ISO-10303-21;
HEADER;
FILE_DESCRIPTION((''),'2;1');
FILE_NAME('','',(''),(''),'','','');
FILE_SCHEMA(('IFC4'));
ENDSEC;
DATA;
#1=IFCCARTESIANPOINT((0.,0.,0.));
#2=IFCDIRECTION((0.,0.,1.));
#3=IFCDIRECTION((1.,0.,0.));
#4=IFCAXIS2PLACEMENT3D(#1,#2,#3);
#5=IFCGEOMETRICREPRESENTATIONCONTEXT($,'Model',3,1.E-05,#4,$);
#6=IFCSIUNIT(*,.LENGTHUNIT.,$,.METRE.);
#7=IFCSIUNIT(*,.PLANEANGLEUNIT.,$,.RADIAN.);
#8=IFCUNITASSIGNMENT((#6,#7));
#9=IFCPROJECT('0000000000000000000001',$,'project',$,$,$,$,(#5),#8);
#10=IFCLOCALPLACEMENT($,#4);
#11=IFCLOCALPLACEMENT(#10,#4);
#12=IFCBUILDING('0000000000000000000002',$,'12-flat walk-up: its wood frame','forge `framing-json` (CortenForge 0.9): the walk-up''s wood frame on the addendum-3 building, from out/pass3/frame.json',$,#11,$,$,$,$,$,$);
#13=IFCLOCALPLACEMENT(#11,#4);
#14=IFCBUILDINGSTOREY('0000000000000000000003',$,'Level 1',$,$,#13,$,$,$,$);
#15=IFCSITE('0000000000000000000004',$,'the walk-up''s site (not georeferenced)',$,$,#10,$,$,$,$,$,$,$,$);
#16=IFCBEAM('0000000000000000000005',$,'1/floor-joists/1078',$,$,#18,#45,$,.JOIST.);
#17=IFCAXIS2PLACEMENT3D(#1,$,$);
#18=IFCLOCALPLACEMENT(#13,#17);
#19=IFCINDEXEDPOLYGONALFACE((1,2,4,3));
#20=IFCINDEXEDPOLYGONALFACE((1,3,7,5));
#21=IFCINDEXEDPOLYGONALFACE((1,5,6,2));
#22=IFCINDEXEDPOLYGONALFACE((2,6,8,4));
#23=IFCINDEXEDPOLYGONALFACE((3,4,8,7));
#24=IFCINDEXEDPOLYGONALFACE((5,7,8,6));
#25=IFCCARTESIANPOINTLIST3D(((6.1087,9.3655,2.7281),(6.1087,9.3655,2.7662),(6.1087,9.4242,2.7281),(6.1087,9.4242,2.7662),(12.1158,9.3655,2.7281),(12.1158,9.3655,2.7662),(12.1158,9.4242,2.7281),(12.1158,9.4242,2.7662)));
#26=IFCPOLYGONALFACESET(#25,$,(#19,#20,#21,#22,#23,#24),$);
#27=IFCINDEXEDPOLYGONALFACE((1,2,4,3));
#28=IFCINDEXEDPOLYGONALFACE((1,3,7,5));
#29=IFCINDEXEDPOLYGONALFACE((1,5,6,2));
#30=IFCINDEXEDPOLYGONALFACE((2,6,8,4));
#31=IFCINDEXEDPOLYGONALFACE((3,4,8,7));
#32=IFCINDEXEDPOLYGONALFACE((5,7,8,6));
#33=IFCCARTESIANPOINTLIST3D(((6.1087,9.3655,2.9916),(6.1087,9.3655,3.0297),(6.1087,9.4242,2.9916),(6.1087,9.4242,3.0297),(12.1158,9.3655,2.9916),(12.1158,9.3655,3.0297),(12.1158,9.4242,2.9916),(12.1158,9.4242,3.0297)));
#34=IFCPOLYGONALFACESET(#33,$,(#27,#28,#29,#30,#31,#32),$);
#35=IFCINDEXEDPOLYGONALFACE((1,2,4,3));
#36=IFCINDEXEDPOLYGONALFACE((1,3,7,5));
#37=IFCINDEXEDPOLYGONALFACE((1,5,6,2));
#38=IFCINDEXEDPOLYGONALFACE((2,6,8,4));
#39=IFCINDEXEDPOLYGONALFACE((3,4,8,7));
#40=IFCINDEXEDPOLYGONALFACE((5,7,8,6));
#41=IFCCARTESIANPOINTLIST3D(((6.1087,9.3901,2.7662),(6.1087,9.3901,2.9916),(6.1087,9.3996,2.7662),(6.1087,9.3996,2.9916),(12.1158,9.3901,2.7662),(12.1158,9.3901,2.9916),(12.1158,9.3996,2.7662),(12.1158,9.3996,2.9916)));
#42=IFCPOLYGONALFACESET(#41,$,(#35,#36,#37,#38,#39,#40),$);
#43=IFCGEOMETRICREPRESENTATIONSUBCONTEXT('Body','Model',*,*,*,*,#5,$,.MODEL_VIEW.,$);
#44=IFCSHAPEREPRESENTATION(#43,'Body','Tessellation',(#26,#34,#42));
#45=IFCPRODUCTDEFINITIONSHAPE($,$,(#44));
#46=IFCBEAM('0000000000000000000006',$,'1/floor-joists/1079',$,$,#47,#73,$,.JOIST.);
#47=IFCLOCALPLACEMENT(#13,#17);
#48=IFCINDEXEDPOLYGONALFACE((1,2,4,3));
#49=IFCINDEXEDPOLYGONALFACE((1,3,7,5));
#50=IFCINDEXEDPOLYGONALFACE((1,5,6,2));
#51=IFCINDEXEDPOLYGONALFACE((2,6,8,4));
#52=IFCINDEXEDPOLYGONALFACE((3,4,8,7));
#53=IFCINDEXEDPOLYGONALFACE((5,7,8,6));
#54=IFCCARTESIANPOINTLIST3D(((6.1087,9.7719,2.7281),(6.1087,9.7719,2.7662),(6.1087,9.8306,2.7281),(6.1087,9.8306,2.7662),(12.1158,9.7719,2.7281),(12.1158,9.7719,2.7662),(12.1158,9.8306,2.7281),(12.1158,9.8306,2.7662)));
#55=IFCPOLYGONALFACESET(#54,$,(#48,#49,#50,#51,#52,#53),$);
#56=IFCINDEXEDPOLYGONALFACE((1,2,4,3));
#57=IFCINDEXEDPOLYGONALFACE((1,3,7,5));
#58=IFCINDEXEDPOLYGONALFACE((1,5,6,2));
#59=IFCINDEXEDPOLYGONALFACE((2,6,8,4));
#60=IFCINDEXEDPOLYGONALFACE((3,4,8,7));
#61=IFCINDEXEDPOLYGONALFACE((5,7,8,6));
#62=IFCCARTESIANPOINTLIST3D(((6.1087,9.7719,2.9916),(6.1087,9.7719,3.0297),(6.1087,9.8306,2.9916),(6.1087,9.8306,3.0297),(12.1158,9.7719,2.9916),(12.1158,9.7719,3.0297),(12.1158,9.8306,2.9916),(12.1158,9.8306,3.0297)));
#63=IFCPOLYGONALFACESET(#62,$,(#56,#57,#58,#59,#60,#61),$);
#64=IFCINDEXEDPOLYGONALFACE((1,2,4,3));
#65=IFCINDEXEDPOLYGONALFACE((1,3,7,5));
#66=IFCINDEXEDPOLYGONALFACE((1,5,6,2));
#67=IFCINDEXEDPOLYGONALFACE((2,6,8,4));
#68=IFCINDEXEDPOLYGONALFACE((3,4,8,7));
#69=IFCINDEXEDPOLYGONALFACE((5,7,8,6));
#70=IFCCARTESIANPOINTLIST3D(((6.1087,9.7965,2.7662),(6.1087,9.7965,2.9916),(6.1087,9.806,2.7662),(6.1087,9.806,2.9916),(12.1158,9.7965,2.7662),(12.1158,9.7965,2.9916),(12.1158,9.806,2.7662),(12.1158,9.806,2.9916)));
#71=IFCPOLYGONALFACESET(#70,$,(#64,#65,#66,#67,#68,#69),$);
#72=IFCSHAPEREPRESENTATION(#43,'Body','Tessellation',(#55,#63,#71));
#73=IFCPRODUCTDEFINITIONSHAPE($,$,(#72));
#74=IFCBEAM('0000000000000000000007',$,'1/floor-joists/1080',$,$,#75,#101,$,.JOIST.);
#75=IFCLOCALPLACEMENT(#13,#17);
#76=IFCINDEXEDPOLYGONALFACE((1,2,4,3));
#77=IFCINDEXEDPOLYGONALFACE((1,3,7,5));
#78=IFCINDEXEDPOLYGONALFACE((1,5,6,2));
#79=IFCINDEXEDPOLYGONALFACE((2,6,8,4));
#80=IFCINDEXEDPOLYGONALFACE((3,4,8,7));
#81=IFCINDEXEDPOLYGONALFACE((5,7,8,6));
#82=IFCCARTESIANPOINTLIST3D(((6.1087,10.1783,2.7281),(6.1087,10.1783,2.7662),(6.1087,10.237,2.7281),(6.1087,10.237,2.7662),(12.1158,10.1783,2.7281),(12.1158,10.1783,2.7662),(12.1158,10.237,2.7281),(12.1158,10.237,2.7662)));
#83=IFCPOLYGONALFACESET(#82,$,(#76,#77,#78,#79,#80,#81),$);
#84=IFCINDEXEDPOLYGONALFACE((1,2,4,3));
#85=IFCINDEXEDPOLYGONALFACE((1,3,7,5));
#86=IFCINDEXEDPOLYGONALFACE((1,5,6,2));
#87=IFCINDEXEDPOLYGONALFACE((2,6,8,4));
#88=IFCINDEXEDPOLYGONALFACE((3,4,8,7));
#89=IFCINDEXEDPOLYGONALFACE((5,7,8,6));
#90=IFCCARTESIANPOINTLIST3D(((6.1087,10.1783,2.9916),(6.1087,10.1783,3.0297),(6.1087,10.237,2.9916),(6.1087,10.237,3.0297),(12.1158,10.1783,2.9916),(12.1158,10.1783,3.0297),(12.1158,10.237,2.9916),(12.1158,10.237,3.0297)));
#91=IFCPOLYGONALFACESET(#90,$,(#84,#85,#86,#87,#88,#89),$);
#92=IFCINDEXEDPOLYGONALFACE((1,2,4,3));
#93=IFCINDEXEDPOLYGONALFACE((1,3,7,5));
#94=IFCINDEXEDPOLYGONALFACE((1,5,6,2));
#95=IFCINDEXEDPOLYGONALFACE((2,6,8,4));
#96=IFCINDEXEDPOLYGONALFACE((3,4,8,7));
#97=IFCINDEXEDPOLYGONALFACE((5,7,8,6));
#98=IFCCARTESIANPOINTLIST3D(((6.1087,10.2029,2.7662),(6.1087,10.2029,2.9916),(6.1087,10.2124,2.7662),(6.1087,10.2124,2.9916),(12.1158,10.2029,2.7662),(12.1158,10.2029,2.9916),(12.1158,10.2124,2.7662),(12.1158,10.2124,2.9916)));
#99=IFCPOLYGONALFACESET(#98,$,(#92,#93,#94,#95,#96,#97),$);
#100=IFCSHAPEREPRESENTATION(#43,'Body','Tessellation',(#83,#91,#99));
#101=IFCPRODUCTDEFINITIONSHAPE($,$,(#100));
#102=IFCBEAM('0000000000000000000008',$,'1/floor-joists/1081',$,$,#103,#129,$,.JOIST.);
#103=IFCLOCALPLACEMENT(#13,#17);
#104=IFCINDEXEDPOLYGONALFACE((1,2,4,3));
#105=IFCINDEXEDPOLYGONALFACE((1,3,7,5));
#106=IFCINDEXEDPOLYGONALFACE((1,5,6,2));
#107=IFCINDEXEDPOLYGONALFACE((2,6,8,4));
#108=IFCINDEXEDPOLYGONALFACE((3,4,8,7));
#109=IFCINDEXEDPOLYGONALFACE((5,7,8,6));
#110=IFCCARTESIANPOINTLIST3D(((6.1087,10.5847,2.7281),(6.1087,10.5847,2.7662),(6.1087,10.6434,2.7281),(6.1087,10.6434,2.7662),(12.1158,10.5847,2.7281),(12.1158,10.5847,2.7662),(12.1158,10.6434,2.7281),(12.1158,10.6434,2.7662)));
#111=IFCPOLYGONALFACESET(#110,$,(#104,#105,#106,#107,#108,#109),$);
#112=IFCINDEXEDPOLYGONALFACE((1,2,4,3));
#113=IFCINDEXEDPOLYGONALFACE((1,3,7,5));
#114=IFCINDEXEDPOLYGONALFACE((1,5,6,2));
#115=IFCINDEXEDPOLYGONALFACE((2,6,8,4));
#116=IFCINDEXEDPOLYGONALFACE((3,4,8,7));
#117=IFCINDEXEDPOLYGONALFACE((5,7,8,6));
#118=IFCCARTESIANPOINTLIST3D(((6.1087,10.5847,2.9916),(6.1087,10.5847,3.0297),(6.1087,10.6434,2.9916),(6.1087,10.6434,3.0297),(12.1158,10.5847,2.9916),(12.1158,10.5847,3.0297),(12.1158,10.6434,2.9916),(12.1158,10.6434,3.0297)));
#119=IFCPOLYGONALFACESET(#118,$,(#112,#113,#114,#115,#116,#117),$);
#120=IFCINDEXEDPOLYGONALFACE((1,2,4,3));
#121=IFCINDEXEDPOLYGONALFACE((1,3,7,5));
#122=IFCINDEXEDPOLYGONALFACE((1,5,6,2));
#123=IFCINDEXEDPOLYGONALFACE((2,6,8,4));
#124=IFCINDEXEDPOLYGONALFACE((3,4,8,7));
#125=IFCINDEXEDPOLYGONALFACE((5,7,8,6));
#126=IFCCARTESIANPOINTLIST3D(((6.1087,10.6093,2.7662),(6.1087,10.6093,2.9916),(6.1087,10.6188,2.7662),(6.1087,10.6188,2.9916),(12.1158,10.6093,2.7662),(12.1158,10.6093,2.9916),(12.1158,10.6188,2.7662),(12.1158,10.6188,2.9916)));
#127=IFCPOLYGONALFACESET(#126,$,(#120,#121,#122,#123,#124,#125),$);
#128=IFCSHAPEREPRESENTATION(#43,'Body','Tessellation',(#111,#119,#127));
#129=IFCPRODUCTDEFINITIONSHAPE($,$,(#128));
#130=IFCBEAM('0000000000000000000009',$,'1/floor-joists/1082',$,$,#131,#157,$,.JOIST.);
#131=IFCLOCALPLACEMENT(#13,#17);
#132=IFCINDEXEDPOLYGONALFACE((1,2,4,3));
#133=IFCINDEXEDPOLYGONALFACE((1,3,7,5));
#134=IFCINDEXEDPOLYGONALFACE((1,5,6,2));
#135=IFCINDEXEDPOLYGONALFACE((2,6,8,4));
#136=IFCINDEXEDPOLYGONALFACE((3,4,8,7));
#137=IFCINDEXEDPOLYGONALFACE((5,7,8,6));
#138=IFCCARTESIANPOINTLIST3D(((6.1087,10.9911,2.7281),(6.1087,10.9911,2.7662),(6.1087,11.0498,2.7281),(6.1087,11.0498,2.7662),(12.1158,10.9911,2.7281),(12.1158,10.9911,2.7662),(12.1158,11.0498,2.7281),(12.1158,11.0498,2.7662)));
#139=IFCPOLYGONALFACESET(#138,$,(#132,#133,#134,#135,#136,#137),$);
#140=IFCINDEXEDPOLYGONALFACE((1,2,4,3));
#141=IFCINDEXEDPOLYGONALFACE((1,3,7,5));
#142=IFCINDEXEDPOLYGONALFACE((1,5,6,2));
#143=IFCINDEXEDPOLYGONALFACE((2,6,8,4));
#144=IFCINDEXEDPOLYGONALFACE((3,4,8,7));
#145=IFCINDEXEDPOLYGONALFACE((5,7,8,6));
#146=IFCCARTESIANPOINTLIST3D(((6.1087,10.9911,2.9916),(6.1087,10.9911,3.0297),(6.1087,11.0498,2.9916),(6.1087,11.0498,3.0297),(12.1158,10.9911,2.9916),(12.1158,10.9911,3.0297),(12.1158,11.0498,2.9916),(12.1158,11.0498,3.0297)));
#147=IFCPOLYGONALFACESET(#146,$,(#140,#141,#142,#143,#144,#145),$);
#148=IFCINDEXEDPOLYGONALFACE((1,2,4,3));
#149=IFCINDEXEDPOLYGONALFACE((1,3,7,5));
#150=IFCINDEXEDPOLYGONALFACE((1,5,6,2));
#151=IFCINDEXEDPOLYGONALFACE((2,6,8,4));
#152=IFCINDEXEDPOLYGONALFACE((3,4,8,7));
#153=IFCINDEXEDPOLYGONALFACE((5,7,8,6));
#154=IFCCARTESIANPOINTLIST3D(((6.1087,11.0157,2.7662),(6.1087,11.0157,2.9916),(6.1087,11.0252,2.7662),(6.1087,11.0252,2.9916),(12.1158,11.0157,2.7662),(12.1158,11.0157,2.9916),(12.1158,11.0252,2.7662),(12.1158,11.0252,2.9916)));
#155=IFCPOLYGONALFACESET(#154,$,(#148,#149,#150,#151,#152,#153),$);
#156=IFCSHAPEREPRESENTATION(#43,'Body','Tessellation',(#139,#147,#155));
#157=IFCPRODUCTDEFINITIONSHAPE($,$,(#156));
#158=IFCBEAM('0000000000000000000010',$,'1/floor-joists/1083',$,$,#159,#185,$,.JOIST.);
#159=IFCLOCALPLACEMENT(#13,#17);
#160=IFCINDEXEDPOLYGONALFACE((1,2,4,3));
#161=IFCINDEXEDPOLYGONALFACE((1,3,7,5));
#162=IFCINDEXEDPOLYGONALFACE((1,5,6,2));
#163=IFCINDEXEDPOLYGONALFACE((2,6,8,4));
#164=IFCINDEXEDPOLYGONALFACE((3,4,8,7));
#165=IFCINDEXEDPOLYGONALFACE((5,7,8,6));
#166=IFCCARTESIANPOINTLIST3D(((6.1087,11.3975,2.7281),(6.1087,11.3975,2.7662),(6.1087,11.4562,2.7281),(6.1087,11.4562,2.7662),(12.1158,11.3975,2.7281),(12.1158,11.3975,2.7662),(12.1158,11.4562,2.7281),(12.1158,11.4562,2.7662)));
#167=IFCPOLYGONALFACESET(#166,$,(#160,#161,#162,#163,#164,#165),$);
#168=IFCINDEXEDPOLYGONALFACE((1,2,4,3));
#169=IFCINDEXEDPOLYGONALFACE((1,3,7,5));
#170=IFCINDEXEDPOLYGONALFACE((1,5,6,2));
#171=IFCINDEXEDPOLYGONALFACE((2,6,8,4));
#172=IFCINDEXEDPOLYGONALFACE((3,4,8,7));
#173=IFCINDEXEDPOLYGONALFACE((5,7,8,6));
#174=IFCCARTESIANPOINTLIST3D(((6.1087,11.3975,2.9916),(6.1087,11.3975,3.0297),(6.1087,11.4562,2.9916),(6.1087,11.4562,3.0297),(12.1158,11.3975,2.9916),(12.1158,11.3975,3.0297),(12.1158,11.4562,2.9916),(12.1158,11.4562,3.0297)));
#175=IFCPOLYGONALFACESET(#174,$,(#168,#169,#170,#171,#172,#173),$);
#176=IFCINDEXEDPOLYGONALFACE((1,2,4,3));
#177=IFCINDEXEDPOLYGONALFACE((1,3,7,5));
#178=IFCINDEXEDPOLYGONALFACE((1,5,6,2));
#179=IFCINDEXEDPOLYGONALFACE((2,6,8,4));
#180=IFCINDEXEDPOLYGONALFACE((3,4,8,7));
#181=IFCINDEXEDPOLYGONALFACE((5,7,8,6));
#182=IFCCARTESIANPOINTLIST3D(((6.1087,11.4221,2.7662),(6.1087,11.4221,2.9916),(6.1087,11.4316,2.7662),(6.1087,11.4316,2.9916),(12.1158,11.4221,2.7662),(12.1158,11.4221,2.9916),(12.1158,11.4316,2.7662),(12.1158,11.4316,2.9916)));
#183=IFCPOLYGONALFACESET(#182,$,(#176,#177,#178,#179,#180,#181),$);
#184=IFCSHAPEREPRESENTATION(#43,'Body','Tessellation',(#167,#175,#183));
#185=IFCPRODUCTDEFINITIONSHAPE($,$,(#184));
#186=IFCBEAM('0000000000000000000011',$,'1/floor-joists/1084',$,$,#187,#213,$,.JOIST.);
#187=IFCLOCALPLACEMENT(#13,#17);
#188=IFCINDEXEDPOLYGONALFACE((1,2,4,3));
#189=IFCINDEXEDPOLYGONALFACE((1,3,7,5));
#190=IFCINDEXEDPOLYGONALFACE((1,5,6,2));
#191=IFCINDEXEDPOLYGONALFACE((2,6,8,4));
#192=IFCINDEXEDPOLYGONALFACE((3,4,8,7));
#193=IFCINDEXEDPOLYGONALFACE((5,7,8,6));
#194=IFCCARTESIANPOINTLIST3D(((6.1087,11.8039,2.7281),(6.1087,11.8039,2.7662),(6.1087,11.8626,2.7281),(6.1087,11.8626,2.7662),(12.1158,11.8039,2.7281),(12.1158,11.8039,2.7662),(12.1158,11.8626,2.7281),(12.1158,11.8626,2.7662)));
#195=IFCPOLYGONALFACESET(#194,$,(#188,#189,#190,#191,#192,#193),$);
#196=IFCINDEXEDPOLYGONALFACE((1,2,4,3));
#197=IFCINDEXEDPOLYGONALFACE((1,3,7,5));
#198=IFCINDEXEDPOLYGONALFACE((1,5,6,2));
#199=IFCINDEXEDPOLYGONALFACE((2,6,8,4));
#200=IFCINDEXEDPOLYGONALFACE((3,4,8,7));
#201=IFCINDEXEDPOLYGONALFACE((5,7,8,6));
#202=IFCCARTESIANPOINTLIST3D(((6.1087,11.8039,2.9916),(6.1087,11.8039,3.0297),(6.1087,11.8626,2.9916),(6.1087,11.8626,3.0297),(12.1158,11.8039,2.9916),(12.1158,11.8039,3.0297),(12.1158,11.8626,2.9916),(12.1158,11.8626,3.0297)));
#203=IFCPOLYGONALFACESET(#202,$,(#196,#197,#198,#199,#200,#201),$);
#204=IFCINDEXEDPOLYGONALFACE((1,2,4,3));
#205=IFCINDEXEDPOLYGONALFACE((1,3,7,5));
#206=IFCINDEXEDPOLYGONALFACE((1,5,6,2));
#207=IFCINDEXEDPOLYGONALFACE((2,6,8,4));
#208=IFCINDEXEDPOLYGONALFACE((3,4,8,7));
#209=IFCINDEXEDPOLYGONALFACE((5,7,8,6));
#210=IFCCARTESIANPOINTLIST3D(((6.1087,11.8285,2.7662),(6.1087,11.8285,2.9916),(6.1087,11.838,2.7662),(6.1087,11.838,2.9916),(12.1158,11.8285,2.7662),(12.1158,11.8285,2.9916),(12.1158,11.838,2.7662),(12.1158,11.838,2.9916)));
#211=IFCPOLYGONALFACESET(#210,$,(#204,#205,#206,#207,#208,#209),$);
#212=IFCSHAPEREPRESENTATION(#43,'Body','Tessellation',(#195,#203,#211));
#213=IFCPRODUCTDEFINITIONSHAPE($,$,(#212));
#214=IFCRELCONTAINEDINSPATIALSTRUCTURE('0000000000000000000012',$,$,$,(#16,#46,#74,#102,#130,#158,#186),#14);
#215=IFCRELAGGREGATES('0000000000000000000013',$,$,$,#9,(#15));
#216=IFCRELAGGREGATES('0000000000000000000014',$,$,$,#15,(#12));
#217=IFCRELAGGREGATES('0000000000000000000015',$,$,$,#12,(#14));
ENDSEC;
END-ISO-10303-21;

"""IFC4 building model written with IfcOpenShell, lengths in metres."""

from ifc_helpers import new_model, si_unit, frame, frame_2d, origin, origin_with_axes, place, context, subcontext, project, spatial, rectangle, extrude, element, save


model = new_model("IFC4")

# Units and contexts
model_context = context("Model", 3, precision=1e-05, world=origin_with_axes())
body_context = subcontext(model_context, "Body", "Model", "MODEL_VIEW")
ifc_project = project(units=[si_unit("LENGTHUNIT", "METRE"), si_unit("PLANEANGLEUNIT", "RADIAN")], contexts=[model_context])

# Site, building, storey
site_placement = place(None, origin_with_axes())
site = spatial("IfcSite", under=ifc_project, at=site_placement, Name="the walk-up's site (not georeferenced)")
building_placement = place(site_placement, origin_with_axes())
building = spatial("IfcBuilding", under=site, at=building_placement, Name="12-flat walk-up: its wood frame", Description="forge `framing-json` (CortenForge 0.9): the walk-up's wood frame on the addendum-3 building, from out/pass3/frame.json")
storey_placement = place(building_placement, origin_with_axes())
storey = spatial("IfcBuildingStorey", under=building, at=storey_placement, Name="Level 1")

# Beams
for number, where, z_axis, x_axis, name in (
    (1, (6.1087, 9.3655, 2.7281), (0.0, 0.0, 1.0), (1.0, 0.0, 0.0), "1/floor-joists/1078"),
    (2, (6.1087, 9.7719, 2.7281), (0.0, 0.0, 1.0), (1.0, 0.0, 0.0), "1/floor-joists/1079"),
    (3, (6.1087, 10.1783, 2.7281), (0.0, 0.0, 1.0), (1.0, 0.0, 0.0), "1/floor-joists/1080"),
):
    element("IfcBeam", number, at=place(storey_placement, frame(where, z_axis=z_axis, x_axis=x_axis)), inside=storey, Name=name, PredefinedType="JOIST", context=body_context, shape_type="SweptSolid", body=[
        extrude(rectangle(XDim=6.0071, YDim=0.0587, at=frame_2d((3.0036, 0.0294))), origin(), (0.0, 0.0, 1.0), 0.0381),
        extrude(rectangle(XDim=6.0071, YDim=0.0587, at=frame_2d((3.0036, 0.0294))), frame((0.0, 0.0, 0.2635)), (0.0, 0.0, 1.0), 0.0381),
        extrude(rectangle(XDim=6.0071, YDim=0.0095, at=frame_2d((3.0036, 0.0048))), frame((0.0, 0.0246, 0.0381)), (0.0, 0.0, 1.0), 0.2254),
    ])
beam_1_placement = place(storey_placement, frame((6.1087, 10.5847, 2.7281), z_axis=(0.0, 0.0, 1.0), x_axis=(1.0, 0.0, 0.0)))
element("IfcBeam", 4, at=beam_1_placement, inside=storey, Name="1/floor-joists/1081", PredefinedType="JOIST", context=body_context, shape_type="SweptSolid", body=[
    extrude(rectangle(XDim=6.0071, YDim=0.0587, at=frame_2d((3.0036, 0.0294))), origin(), (0.0, 0.0, 1.0), 0.0381),
    extrude(rectangle(XDim=6.0071, YDim=0.0587, at=frame_2d((3.0036, 0.0294))), frame((0.0, 0.0, 0.2635)), (0.0, 0.0, 1.0), 0.0381),
    extrude(rectangle(XDim=6.0071, YDim=0.0095, at=frame_2d((3.0036, 0.0048))), frame((0.0, 0.0246, 0.0381)), (0.0, 0.0, 1.0), 0.2254),
])
for number, where, z_axis, x_axis, name in (
    (5, (6.1087, 10.9911, 2.7281), (0.0, 0.0, 1.0), (1.0, 0.0, 0.0), "1/floor-joists/1082"),
    (6, (6.1087, 11.3975, 2.7281), (0.0, 0.0, 1.0), (1.0, 0.0, 0.0), "1/floor-joists/1083"),
    (7, (6.1087, 11.8039, 2.7281), (0.0, 0.0, 1.0), (1.0, 0.0, 0.0), "1/floor-joists/1084"),
):
    element("IfcBeam", number, at=place(storey_placement, frame(where, z_axis=z_axis, x_axis=x_axis)), inside=storey, Name=name, PredefinedType="JOIST", context=body_context, shape_type="SweptSolid", body=[
        extrude(rectangle(XDim=6.0071, YDim=0.0587, at=frame_2d((3.0036, 0.0294))), origin(), (0.0, 0.0, 1.0), 0.0381),
        extrude(rectangle(XDim=6.0071, YDim=0.0587, at=frame_2d((3.0036, 0.0294))), frame((0.0, 0.0, 0.2635)), (0.0, 0.0, 1.0), 0.0381),
        extrude(rectangle(XDim=6.0071, YDim=0.0095, at=frame_2d((3.0036, 0.0048))), frame((0.0, 0.0246, 0.0381)), (0.0, 0.0, 1.0), 0.2254),
    ])

save(model, "model.ifc")
